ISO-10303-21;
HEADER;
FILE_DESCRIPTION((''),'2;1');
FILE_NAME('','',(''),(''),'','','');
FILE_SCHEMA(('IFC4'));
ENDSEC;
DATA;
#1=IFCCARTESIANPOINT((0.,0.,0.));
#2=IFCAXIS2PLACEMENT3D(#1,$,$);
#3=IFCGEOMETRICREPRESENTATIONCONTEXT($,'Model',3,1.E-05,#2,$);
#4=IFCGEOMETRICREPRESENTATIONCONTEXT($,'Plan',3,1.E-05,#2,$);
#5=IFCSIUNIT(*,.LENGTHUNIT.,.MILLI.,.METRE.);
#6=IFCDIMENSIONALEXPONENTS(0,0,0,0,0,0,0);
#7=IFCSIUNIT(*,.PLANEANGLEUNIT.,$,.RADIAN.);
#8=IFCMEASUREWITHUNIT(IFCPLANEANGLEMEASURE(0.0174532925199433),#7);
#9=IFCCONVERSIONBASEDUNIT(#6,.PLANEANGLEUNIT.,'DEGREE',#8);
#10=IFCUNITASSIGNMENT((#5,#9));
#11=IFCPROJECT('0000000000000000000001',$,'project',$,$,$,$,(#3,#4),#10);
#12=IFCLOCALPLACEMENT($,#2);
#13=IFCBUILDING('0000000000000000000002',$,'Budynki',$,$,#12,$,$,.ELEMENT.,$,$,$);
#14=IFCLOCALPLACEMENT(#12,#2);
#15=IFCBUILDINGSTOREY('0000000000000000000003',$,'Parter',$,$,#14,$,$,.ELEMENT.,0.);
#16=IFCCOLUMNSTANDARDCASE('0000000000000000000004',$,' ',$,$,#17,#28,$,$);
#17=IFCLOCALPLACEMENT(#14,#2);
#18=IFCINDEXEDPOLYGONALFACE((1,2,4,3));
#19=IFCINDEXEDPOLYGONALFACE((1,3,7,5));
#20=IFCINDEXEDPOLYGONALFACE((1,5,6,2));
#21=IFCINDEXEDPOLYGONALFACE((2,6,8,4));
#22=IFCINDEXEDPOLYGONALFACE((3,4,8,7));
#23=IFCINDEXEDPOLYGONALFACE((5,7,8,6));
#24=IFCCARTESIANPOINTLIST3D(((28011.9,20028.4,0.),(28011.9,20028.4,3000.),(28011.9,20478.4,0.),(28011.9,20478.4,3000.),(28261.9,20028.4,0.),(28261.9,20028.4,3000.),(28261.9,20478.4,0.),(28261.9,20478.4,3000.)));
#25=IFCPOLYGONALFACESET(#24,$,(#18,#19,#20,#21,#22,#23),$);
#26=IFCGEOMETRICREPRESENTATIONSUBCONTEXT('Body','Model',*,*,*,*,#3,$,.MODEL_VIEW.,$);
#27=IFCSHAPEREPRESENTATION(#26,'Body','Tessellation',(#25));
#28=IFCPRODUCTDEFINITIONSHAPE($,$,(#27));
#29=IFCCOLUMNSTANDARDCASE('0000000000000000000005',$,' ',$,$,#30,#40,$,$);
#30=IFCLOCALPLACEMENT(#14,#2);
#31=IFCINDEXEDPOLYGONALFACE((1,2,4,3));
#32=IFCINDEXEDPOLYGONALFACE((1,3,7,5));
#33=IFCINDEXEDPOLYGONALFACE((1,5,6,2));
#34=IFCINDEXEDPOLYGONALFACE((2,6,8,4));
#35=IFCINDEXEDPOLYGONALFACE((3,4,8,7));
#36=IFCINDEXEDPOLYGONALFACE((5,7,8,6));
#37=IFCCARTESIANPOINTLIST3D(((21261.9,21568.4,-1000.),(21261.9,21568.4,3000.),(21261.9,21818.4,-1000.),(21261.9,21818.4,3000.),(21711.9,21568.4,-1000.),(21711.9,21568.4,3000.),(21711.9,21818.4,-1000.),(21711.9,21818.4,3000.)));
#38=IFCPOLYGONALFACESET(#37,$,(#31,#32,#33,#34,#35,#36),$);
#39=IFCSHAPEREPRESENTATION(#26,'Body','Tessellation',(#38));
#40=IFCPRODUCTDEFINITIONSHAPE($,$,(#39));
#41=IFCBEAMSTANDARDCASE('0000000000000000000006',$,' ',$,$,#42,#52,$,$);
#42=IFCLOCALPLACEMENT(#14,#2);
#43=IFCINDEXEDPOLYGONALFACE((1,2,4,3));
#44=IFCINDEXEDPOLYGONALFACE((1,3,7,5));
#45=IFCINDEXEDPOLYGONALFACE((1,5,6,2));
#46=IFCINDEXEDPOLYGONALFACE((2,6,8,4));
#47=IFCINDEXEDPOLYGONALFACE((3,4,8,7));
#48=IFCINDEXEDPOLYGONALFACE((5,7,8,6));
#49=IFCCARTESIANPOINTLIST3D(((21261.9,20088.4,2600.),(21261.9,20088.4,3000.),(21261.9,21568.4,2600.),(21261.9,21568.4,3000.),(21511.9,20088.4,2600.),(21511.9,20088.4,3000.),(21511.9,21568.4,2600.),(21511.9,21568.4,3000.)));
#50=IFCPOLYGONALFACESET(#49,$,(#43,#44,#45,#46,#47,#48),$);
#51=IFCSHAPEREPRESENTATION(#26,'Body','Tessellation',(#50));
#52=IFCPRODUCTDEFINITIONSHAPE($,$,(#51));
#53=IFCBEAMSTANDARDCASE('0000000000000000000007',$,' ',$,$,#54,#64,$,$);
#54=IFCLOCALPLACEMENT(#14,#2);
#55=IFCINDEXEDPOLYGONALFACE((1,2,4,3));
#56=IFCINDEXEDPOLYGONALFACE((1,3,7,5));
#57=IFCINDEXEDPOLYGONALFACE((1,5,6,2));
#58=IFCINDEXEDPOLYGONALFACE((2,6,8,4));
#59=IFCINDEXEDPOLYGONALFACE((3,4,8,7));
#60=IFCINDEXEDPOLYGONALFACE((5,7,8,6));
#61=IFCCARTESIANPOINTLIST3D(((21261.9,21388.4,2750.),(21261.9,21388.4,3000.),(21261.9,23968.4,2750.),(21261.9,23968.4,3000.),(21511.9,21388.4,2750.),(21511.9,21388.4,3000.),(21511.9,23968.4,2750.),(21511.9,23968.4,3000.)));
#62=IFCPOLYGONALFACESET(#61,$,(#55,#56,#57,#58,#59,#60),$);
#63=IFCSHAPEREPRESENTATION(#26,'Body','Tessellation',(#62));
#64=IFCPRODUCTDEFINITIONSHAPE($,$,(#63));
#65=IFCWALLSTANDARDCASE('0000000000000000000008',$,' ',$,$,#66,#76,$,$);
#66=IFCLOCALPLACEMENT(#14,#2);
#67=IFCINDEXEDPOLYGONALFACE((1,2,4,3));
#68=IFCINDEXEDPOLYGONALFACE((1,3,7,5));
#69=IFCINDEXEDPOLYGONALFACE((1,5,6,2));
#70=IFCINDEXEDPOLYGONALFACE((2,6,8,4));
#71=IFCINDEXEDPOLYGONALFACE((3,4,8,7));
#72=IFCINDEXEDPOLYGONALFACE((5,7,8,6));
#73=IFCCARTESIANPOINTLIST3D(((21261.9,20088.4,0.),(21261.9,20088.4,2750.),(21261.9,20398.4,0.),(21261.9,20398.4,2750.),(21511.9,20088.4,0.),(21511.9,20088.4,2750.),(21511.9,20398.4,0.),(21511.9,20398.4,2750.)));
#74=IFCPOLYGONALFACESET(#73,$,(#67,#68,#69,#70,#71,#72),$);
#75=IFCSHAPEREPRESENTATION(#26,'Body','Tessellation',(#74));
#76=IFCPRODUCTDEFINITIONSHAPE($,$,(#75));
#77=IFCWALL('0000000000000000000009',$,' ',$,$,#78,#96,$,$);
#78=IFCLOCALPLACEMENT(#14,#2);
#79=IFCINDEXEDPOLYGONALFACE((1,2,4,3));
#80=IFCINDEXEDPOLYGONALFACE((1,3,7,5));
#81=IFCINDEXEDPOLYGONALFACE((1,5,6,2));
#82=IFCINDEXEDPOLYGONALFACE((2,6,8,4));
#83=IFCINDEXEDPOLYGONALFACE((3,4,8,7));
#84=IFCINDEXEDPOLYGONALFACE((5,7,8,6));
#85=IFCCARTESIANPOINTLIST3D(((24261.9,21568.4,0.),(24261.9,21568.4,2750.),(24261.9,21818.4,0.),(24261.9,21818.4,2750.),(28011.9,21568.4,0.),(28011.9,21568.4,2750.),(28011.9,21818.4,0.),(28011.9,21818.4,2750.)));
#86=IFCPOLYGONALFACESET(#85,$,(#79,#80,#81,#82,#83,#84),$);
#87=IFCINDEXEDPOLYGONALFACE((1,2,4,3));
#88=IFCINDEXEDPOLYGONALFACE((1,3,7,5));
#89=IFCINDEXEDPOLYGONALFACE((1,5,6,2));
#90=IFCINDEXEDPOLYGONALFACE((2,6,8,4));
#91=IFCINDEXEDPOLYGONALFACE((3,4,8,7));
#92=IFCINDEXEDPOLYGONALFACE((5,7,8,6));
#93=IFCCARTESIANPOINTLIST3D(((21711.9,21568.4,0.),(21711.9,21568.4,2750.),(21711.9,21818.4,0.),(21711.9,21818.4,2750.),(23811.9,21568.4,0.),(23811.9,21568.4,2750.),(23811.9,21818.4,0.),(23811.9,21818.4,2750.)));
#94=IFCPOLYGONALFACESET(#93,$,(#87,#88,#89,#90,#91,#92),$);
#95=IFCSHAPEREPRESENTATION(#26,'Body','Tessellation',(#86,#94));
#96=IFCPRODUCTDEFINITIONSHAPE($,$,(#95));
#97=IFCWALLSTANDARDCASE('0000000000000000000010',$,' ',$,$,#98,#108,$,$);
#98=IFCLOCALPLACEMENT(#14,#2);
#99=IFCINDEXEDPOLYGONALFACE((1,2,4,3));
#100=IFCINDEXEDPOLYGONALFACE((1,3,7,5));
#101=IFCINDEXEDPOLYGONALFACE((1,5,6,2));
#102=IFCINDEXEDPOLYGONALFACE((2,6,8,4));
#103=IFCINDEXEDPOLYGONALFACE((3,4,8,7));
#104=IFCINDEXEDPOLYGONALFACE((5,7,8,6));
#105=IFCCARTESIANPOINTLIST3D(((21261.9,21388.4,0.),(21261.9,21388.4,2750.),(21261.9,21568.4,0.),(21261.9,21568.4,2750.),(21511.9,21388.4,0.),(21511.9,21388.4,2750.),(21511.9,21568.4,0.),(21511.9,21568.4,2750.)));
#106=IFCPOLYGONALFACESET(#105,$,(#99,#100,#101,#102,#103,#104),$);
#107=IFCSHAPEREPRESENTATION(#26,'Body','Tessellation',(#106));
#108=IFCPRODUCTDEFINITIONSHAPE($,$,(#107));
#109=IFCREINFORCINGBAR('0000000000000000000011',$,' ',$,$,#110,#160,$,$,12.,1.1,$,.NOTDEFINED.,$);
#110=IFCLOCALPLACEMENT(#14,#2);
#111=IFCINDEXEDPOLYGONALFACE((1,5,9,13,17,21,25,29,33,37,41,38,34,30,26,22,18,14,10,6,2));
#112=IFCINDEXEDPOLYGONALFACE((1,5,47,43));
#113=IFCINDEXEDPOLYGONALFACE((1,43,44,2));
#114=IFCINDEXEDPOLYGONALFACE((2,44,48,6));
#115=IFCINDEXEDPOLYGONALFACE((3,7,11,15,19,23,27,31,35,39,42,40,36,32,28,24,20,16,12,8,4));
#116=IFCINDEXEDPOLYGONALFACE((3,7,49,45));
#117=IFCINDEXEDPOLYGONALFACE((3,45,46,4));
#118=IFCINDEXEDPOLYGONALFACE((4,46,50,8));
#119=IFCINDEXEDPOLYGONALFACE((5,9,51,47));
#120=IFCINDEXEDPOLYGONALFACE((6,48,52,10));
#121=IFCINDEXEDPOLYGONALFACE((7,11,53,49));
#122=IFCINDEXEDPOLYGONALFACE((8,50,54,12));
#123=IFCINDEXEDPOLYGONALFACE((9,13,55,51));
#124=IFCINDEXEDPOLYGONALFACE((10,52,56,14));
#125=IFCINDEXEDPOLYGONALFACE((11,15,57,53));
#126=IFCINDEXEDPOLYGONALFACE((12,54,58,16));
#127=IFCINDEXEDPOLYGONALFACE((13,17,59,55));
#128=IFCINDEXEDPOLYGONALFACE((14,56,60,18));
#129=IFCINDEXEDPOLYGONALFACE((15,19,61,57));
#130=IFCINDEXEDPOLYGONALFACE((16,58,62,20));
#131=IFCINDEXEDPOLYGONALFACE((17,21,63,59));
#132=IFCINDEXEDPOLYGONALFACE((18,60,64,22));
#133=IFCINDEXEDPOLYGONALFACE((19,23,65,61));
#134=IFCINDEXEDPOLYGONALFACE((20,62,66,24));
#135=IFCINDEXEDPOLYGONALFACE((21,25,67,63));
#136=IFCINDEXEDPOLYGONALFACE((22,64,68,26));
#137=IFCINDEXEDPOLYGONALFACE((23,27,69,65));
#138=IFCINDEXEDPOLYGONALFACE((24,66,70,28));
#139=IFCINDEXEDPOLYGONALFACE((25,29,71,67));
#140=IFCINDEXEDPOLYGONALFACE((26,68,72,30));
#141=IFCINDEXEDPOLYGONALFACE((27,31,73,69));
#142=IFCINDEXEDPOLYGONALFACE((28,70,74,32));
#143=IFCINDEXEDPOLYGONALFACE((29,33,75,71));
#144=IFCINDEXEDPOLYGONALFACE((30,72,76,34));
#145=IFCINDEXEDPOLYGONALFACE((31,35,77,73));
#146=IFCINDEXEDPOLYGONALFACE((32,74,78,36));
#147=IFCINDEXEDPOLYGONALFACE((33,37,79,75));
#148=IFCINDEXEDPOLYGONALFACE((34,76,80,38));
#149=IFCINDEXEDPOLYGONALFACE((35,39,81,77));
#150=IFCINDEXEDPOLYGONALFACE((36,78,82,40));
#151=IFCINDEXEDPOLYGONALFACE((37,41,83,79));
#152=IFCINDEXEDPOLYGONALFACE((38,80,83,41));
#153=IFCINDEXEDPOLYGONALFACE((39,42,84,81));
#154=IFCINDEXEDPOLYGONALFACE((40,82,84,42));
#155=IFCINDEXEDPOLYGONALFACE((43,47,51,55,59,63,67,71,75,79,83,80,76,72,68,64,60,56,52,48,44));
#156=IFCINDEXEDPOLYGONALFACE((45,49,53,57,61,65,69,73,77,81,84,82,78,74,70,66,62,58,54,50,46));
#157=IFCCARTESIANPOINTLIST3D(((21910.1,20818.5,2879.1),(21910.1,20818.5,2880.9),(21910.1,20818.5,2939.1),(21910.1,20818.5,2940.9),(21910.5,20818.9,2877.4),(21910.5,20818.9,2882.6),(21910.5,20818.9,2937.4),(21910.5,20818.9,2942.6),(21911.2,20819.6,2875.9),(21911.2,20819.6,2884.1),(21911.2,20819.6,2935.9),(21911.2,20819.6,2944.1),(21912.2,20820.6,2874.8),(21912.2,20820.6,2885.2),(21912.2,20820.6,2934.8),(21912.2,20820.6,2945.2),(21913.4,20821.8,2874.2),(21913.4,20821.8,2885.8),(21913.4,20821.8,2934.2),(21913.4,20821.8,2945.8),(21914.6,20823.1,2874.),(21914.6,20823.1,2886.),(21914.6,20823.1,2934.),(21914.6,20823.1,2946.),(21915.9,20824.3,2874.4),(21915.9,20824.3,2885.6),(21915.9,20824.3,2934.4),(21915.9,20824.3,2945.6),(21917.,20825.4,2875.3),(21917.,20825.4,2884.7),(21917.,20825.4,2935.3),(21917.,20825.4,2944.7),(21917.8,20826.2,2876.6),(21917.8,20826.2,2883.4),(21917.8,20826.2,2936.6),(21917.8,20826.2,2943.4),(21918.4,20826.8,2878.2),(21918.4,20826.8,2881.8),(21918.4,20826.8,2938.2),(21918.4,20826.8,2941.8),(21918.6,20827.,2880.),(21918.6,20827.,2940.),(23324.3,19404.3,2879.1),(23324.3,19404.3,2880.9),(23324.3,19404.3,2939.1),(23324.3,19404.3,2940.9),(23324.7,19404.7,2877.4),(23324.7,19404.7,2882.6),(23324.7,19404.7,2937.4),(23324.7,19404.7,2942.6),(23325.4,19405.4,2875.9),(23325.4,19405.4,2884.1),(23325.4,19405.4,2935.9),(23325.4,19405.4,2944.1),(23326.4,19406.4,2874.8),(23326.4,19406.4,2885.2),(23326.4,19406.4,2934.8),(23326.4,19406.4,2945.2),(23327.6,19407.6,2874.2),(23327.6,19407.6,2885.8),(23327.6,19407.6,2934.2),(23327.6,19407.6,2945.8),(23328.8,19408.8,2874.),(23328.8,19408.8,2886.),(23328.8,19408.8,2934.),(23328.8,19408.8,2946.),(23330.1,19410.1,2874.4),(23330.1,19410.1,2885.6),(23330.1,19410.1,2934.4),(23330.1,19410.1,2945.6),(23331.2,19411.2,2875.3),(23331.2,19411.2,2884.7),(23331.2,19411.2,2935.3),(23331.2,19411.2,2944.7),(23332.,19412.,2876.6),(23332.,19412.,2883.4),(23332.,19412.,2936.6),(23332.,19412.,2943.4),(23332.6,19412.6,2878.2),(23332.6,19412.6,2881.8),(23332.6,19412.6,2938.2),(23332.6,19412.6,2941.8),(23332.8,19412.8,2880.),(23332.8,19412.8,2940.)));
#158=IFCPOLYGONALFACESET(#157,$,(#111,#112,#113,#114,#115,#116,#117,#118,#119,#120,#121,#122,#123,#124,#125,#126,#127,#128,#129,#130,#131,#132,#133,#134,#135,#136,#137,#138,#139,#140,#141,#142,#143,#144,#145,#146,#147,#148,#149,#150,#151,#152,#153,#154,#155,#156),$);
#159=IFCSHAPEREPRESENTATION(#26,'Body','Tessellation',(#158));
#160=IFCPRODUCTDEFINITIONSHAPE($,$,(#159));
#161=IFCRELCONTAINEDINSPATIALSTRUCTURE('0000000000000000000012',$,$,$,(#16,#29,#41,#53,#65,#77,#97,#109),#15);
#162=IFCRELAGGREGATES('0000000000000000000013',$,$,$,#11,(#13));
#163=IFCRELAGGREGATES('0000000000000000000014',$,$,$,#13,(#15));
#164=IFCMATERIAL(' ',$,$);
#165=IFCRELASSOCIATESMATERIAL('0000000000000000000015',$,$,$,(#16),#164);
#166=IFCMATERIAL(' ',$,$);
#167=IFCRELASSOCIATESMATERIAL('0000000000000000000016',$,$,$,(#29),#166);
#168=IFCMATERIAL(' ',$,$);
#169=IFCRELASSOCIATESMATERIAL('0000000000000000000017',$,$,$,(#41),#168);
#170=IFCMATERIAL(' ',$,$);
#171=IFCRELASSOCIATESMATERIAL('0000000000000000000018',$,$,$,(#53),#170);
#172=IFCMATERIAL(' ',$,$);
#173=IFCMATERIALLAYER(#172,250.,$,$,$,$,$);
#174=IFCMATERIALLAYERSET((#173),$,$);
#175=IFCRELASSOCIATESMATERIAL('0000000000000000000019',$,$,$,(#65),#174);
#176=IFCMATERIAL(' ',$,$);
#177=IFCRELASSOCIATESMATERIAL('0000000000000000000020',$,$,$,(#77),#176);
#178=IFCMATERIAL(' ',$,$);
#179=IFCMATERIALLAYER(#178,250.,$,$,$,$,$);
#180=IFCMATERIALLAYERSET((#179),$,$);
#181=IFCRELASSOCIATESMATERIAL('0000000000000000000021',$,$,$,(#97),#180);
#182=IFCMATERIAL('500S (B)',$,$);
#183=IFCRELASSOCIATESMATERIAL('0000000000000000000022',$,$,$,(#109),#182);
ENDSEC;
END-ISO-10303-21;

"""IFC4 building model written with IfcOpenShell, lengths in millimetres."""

from ifc_helpers import new_model, entity, si_unit, converted_unit, frame, frame_2d, origin, origin_with_axes, place, context, subcontext, project, spatial, polyline, rectangle, outline, extrude, source, transform, mapped, material, layer, layer_set, layer_usage, material_profile, profile_set, profile_usage, element, save


model = new_model("IFC4")

# Units and contexts
model_context = context("Model", 3, precision=1e-05, world=origin())
plan_context = context("Plan", 3, precision=1e-05, world=origin())
body_context = subcontext(model_context, "Body", "Model", "MODEL_VIEW")
ifc_project = project(units=[si_unit("LENGTHUNIT", "METRE", prefix="MILLI"), converted_unit("PLANEANGLEUNIT", "DEGREE", entity("IfcPlaneAngleMeasure", 0.0174532925199433), si_unit("PLANEANGLEUNIT", "RADIAN"), dimensions=[0, 0, 0, 0, 0, 0, 0])], contexts=[model_context, plan_context])

# Building, storey
building_placement = place(None, origin())
building = spatial("IfcBuilding", under=ifc_project, at=building_placement, Name="Budynki", CompositionType="ELEMENT")
storey_placement = place(building_placement, origin())
storey = spatial("IfcBuildingStorey", under=building, at=storey_placement, Name="Parter", CompositionType="ELEMENT", Elevation=0.0)

# Columns
ifc_material_1 = material(Name=" ")
ifc_material_profile_1 = material_profile(ifc_material_1, rectangle(XDim=450.0, YDim=250.0, at=frame_2d((-125.0, 225.0), x_axis=(0.0, 1.0))))
ifc_profile_set_1 = profile_set([ifc_material_profile_1])
ifc_profile_usage_1 = profile_usage(ifc_profile_set_1)
column_1_placement = place(storey_placement, frame((28011.9, 20028.4, 0.0)))
element("IfcColumnStandardCase", 1, at=column_1_placement, inside=storey, material=ifc_profile_usage_1, Name=" ", context=body_context, shape_type="SweptSolid", body=[
    extrude(rectangle(XDim=450.0, YDim=250.0, at=frame_2d((-125.0, 225.0), x_axis=(0.0, 1.0))), frame((250.0, 0.0, 0.0), z_axis=(0.0, 0.0, 1.0), x_axis=(1.0, 0.0, 0.0)), (0.0, 0.0, 1.0), 3000.0),
])
ifc_material_2 = material(Name=" ")
ifc_material_profile_2 = material_profile(ifc_material_2, outline(polyline([(450.0, 0.0), (450.0, 250.0), (0.0, 250.0), (0.0, 0.0), (450.0, 0.0)])))
ifc_profile_set_2 = profile_set([ifc_material_profile_2])
ifc_profile_usage_2 = profile_usage(ifc_profile_set_2)
column_2_placement = place(storey_placement, frame((21261.9, 21568.4, -1000.0)))
element("IfcColumnStandardCase", 2, at=column_2_placement, inside=storey, material=ifc_profile_usage_2, Name=" ", context=body_context, shape_type="SweptSolid", body=[
    extrude(outline(polyline([(450.0, 0.0), (450.0, 250.0), (0.0, 250.0), (0.0, 0.0), (450.0, 0.0)])), origin_with_axes(), (0.0, 0.0, 1.0), 4000.0),
])

# Beams
ifc_material_3 = material(Name=" ")
ifc_material_profile_3 = material_profile(ifc_material_3, rectangle(XDim=250.0, YDim=400.0, at=frame_2d((200.0, -125.0), x_axis=(0.0, 1.0))))
ifc_profile_set_3 = profile_set([ifc_material_profile_3])
ifc_profile_usage_3 = profile_usage(ifc_profile_set_3)
beam_1_placement = place(storey_placement, frame((21261.9, 21568.4, 2600.0), z_axis=(0.0, 0.0, 1.0), x_axis=(0.0, -1.0, 0.0)))
element("IfcBeamStandardCase", 3, at=beam_1_placement, inside=storey, material=ifc_profile_usage_3, Name=" ", context=body_context, shape_type="SweptSolid", body=[
    extrude(rectangle(XDim=250.0, YDim=400.0, at=frame_2d((200.0, -125.0), x_axis=(0.0, 1.0))), frame((0.0, 0.0, 0.0), z_axis=(1.0, 0.0, 0.0), x_axis=(0.0, 0.0, 1.0)), (0.0, 0.0, 1.0), 1480.0),
])
ifc_material_4 = material(Name=" ")
ifc_material_profile_4 = material_profile(ifc_material_4, rectangle(XDim=250.0, YDim=250.0, at=frame_2d((125.0, -125.0), x_axis=(0.0, 1.0))))
ifc_profile_set_4 = profile_set([ifc_material_profile_4])
ifc_profile_usage_4 = profile_usage(ifc_profile_set_4)
beam_2_placement = place(storey_placement, frame((21511.9, 21388.4, 2750.0), z_axis=(0.0, 0.0, 1.0), x_axis=(0.0, 1.0, 0.0)))
element("IfcBeamStandardCase", 4, at=beam_2_placement, inside=storey, material=ifc_profile_usage_4, Name=" ", context=body_context, shape_type="SweptSolid", body=[
    extrude(rectangle(XDim=250.0, YDim=250.0, at=frame_2d((125.0, -125.0), x_axis=(0.0, 1.0))), frame((0.0, 0.0, 0.0), z_axis=(1.0, 0.0, 0.0), x_axis=(0.0, 0.0, 1.0)), (0.0, 0.0, 1.0), 2580.0),
])

# Walls
ifc_material_5 = material(Name=" ")
ifc_layer_1 = layer(ifc_material_5, 250.0)
ifc_layer_set_1 = layer_set([ifc_layer_1])
ifc_layer_usage_1 = layer_usage(ifc_layer_set_1, "AXIS2", "POSITIVE", 0.0)
wall_1_placement = place(storey_placement, frame((21511.9, 20088.4, 0.0), z_axis=(0.0, 0.0, 1.0), x_axis=(0.0, 1.0, 0.0)))
element("IfcWallStandardCase", 5, at=wall_1_placement, inside=storey, material=ifc_layer_usage_1, Name=" ", context=body_context, shape_type="SweptSolid", body=[
    extrude(rectangle(XDim=310.0, YDim=250.0, at=frame_2d((155.0, 125.0), x_axis=(1.0, 0.0))), origin_with_axes(), (0.0, 0.0, 1.0), 2750.0),
])
ifc_material_6 = material(Name=" ")
wall_2_placement = place(storey_placement, frame((21711.9, 21568.4, 0.0)))
element("IfcWall", 6, at=wall_2_placement, inside=storey, material=ifc_material_6, Name=" ", context=body_context, shape_type="SweptSolid", body=[
    extrude(rectangle(XDim=250.0, YDim=3750.0, at=frame_2d((1875.0, -125.0), x_axis=(0.0, -1.0))), frame((2550.0, 250.0, 0.0), z_axis=(0.0, 0.0, 1.0), x_axis=(1.0, 0.0, 0.0)), (0.0, 0.0, 1.0), 2750.0),
    extrude(rectangle(XDim=250.0, YDim=2100.0, at=frame_2d((-1050.0, 125.0), x_axis=(0.0, 1.0))), frame((2100.0, 0.0, 0.0), z_axis=(0.0, 0.0, 1.0), x_axis=(1.0, 0.0, 0.0)), (0.0, 0.0, 1.0), 2750.0),
])
ifc_material_7 = material(Name=" ")
ifc_layer_2 = layer(ifc_material_7, 250.0)
ifc_layer_set_2 = layer_set([ifc_layer_2])
ifc_layer_usage_2 = layer_usage(ifc_layer_set_2, "AXIS2", "POSITIVE", 0.0)
wall_3_placement = place(storey_placement, frame((21261.9, 21568.4, 0.0), z_axis=(0.0, 0.0, 1.0), x_axis=(0.0, -1.0, 0.0)))
element("IfcWallStandardCase", 7, at=wall_3_placement, inside=storey, material=ifc_layer_usage_2, Name=" ", context=body_context, shape_type="SweptSolid", body=[
    extrude(rectangle(XDim=180.0, YDim=250.0, at=frame_2d((90.0, 125.0), x_axis=(1.0, 0.0))), origin_with_axes(), (0.0, 0.0, 1.0), 2750.0),
])

# Reinforcing bar
ifc_material_8 = material(Name="500S (B)")
shared_shape_1 = source(origin_with_axes(), body_context, "Body", "AdvancedSweptSolid", [
    entity("IfcSweptDiskSolid", entity("IfcPolyline", [entity("IfcCartesianPoint", [0.0, 0.0, 0.0]), entity("IfcCartesianPoint", [1414.2, -1414.2, 0.0])]), 6.0, None, 0.0, 1.0),
])
reinforcing_bar_1_placement = place(storey_placement, frame((21914.3, 20822.7, 2880.0)))
element("IfcReinforcingBar", 8, at=reinforcing_bar_1_placement, inside=storey, material=ifc_material_8, Name=" ", CrossSectionArea=1.1, NominalDiameter=12.0, PredefinedType="NOTDEFINED", context=body_context, shape_type="MappedRepresentation", body=[
    mapped(shared_shape_1, transform((0.0, 0.0, 0.0), y_axis=(0.0, 1.0, 0.0), scale=1.0)),
    mapped(shared_shape_1, transform((0.0, 0.0, 60.0), y_axis=(0.0, 1.0, 0.0), scale=1.0)),
])

save(model, "model.ifc")
